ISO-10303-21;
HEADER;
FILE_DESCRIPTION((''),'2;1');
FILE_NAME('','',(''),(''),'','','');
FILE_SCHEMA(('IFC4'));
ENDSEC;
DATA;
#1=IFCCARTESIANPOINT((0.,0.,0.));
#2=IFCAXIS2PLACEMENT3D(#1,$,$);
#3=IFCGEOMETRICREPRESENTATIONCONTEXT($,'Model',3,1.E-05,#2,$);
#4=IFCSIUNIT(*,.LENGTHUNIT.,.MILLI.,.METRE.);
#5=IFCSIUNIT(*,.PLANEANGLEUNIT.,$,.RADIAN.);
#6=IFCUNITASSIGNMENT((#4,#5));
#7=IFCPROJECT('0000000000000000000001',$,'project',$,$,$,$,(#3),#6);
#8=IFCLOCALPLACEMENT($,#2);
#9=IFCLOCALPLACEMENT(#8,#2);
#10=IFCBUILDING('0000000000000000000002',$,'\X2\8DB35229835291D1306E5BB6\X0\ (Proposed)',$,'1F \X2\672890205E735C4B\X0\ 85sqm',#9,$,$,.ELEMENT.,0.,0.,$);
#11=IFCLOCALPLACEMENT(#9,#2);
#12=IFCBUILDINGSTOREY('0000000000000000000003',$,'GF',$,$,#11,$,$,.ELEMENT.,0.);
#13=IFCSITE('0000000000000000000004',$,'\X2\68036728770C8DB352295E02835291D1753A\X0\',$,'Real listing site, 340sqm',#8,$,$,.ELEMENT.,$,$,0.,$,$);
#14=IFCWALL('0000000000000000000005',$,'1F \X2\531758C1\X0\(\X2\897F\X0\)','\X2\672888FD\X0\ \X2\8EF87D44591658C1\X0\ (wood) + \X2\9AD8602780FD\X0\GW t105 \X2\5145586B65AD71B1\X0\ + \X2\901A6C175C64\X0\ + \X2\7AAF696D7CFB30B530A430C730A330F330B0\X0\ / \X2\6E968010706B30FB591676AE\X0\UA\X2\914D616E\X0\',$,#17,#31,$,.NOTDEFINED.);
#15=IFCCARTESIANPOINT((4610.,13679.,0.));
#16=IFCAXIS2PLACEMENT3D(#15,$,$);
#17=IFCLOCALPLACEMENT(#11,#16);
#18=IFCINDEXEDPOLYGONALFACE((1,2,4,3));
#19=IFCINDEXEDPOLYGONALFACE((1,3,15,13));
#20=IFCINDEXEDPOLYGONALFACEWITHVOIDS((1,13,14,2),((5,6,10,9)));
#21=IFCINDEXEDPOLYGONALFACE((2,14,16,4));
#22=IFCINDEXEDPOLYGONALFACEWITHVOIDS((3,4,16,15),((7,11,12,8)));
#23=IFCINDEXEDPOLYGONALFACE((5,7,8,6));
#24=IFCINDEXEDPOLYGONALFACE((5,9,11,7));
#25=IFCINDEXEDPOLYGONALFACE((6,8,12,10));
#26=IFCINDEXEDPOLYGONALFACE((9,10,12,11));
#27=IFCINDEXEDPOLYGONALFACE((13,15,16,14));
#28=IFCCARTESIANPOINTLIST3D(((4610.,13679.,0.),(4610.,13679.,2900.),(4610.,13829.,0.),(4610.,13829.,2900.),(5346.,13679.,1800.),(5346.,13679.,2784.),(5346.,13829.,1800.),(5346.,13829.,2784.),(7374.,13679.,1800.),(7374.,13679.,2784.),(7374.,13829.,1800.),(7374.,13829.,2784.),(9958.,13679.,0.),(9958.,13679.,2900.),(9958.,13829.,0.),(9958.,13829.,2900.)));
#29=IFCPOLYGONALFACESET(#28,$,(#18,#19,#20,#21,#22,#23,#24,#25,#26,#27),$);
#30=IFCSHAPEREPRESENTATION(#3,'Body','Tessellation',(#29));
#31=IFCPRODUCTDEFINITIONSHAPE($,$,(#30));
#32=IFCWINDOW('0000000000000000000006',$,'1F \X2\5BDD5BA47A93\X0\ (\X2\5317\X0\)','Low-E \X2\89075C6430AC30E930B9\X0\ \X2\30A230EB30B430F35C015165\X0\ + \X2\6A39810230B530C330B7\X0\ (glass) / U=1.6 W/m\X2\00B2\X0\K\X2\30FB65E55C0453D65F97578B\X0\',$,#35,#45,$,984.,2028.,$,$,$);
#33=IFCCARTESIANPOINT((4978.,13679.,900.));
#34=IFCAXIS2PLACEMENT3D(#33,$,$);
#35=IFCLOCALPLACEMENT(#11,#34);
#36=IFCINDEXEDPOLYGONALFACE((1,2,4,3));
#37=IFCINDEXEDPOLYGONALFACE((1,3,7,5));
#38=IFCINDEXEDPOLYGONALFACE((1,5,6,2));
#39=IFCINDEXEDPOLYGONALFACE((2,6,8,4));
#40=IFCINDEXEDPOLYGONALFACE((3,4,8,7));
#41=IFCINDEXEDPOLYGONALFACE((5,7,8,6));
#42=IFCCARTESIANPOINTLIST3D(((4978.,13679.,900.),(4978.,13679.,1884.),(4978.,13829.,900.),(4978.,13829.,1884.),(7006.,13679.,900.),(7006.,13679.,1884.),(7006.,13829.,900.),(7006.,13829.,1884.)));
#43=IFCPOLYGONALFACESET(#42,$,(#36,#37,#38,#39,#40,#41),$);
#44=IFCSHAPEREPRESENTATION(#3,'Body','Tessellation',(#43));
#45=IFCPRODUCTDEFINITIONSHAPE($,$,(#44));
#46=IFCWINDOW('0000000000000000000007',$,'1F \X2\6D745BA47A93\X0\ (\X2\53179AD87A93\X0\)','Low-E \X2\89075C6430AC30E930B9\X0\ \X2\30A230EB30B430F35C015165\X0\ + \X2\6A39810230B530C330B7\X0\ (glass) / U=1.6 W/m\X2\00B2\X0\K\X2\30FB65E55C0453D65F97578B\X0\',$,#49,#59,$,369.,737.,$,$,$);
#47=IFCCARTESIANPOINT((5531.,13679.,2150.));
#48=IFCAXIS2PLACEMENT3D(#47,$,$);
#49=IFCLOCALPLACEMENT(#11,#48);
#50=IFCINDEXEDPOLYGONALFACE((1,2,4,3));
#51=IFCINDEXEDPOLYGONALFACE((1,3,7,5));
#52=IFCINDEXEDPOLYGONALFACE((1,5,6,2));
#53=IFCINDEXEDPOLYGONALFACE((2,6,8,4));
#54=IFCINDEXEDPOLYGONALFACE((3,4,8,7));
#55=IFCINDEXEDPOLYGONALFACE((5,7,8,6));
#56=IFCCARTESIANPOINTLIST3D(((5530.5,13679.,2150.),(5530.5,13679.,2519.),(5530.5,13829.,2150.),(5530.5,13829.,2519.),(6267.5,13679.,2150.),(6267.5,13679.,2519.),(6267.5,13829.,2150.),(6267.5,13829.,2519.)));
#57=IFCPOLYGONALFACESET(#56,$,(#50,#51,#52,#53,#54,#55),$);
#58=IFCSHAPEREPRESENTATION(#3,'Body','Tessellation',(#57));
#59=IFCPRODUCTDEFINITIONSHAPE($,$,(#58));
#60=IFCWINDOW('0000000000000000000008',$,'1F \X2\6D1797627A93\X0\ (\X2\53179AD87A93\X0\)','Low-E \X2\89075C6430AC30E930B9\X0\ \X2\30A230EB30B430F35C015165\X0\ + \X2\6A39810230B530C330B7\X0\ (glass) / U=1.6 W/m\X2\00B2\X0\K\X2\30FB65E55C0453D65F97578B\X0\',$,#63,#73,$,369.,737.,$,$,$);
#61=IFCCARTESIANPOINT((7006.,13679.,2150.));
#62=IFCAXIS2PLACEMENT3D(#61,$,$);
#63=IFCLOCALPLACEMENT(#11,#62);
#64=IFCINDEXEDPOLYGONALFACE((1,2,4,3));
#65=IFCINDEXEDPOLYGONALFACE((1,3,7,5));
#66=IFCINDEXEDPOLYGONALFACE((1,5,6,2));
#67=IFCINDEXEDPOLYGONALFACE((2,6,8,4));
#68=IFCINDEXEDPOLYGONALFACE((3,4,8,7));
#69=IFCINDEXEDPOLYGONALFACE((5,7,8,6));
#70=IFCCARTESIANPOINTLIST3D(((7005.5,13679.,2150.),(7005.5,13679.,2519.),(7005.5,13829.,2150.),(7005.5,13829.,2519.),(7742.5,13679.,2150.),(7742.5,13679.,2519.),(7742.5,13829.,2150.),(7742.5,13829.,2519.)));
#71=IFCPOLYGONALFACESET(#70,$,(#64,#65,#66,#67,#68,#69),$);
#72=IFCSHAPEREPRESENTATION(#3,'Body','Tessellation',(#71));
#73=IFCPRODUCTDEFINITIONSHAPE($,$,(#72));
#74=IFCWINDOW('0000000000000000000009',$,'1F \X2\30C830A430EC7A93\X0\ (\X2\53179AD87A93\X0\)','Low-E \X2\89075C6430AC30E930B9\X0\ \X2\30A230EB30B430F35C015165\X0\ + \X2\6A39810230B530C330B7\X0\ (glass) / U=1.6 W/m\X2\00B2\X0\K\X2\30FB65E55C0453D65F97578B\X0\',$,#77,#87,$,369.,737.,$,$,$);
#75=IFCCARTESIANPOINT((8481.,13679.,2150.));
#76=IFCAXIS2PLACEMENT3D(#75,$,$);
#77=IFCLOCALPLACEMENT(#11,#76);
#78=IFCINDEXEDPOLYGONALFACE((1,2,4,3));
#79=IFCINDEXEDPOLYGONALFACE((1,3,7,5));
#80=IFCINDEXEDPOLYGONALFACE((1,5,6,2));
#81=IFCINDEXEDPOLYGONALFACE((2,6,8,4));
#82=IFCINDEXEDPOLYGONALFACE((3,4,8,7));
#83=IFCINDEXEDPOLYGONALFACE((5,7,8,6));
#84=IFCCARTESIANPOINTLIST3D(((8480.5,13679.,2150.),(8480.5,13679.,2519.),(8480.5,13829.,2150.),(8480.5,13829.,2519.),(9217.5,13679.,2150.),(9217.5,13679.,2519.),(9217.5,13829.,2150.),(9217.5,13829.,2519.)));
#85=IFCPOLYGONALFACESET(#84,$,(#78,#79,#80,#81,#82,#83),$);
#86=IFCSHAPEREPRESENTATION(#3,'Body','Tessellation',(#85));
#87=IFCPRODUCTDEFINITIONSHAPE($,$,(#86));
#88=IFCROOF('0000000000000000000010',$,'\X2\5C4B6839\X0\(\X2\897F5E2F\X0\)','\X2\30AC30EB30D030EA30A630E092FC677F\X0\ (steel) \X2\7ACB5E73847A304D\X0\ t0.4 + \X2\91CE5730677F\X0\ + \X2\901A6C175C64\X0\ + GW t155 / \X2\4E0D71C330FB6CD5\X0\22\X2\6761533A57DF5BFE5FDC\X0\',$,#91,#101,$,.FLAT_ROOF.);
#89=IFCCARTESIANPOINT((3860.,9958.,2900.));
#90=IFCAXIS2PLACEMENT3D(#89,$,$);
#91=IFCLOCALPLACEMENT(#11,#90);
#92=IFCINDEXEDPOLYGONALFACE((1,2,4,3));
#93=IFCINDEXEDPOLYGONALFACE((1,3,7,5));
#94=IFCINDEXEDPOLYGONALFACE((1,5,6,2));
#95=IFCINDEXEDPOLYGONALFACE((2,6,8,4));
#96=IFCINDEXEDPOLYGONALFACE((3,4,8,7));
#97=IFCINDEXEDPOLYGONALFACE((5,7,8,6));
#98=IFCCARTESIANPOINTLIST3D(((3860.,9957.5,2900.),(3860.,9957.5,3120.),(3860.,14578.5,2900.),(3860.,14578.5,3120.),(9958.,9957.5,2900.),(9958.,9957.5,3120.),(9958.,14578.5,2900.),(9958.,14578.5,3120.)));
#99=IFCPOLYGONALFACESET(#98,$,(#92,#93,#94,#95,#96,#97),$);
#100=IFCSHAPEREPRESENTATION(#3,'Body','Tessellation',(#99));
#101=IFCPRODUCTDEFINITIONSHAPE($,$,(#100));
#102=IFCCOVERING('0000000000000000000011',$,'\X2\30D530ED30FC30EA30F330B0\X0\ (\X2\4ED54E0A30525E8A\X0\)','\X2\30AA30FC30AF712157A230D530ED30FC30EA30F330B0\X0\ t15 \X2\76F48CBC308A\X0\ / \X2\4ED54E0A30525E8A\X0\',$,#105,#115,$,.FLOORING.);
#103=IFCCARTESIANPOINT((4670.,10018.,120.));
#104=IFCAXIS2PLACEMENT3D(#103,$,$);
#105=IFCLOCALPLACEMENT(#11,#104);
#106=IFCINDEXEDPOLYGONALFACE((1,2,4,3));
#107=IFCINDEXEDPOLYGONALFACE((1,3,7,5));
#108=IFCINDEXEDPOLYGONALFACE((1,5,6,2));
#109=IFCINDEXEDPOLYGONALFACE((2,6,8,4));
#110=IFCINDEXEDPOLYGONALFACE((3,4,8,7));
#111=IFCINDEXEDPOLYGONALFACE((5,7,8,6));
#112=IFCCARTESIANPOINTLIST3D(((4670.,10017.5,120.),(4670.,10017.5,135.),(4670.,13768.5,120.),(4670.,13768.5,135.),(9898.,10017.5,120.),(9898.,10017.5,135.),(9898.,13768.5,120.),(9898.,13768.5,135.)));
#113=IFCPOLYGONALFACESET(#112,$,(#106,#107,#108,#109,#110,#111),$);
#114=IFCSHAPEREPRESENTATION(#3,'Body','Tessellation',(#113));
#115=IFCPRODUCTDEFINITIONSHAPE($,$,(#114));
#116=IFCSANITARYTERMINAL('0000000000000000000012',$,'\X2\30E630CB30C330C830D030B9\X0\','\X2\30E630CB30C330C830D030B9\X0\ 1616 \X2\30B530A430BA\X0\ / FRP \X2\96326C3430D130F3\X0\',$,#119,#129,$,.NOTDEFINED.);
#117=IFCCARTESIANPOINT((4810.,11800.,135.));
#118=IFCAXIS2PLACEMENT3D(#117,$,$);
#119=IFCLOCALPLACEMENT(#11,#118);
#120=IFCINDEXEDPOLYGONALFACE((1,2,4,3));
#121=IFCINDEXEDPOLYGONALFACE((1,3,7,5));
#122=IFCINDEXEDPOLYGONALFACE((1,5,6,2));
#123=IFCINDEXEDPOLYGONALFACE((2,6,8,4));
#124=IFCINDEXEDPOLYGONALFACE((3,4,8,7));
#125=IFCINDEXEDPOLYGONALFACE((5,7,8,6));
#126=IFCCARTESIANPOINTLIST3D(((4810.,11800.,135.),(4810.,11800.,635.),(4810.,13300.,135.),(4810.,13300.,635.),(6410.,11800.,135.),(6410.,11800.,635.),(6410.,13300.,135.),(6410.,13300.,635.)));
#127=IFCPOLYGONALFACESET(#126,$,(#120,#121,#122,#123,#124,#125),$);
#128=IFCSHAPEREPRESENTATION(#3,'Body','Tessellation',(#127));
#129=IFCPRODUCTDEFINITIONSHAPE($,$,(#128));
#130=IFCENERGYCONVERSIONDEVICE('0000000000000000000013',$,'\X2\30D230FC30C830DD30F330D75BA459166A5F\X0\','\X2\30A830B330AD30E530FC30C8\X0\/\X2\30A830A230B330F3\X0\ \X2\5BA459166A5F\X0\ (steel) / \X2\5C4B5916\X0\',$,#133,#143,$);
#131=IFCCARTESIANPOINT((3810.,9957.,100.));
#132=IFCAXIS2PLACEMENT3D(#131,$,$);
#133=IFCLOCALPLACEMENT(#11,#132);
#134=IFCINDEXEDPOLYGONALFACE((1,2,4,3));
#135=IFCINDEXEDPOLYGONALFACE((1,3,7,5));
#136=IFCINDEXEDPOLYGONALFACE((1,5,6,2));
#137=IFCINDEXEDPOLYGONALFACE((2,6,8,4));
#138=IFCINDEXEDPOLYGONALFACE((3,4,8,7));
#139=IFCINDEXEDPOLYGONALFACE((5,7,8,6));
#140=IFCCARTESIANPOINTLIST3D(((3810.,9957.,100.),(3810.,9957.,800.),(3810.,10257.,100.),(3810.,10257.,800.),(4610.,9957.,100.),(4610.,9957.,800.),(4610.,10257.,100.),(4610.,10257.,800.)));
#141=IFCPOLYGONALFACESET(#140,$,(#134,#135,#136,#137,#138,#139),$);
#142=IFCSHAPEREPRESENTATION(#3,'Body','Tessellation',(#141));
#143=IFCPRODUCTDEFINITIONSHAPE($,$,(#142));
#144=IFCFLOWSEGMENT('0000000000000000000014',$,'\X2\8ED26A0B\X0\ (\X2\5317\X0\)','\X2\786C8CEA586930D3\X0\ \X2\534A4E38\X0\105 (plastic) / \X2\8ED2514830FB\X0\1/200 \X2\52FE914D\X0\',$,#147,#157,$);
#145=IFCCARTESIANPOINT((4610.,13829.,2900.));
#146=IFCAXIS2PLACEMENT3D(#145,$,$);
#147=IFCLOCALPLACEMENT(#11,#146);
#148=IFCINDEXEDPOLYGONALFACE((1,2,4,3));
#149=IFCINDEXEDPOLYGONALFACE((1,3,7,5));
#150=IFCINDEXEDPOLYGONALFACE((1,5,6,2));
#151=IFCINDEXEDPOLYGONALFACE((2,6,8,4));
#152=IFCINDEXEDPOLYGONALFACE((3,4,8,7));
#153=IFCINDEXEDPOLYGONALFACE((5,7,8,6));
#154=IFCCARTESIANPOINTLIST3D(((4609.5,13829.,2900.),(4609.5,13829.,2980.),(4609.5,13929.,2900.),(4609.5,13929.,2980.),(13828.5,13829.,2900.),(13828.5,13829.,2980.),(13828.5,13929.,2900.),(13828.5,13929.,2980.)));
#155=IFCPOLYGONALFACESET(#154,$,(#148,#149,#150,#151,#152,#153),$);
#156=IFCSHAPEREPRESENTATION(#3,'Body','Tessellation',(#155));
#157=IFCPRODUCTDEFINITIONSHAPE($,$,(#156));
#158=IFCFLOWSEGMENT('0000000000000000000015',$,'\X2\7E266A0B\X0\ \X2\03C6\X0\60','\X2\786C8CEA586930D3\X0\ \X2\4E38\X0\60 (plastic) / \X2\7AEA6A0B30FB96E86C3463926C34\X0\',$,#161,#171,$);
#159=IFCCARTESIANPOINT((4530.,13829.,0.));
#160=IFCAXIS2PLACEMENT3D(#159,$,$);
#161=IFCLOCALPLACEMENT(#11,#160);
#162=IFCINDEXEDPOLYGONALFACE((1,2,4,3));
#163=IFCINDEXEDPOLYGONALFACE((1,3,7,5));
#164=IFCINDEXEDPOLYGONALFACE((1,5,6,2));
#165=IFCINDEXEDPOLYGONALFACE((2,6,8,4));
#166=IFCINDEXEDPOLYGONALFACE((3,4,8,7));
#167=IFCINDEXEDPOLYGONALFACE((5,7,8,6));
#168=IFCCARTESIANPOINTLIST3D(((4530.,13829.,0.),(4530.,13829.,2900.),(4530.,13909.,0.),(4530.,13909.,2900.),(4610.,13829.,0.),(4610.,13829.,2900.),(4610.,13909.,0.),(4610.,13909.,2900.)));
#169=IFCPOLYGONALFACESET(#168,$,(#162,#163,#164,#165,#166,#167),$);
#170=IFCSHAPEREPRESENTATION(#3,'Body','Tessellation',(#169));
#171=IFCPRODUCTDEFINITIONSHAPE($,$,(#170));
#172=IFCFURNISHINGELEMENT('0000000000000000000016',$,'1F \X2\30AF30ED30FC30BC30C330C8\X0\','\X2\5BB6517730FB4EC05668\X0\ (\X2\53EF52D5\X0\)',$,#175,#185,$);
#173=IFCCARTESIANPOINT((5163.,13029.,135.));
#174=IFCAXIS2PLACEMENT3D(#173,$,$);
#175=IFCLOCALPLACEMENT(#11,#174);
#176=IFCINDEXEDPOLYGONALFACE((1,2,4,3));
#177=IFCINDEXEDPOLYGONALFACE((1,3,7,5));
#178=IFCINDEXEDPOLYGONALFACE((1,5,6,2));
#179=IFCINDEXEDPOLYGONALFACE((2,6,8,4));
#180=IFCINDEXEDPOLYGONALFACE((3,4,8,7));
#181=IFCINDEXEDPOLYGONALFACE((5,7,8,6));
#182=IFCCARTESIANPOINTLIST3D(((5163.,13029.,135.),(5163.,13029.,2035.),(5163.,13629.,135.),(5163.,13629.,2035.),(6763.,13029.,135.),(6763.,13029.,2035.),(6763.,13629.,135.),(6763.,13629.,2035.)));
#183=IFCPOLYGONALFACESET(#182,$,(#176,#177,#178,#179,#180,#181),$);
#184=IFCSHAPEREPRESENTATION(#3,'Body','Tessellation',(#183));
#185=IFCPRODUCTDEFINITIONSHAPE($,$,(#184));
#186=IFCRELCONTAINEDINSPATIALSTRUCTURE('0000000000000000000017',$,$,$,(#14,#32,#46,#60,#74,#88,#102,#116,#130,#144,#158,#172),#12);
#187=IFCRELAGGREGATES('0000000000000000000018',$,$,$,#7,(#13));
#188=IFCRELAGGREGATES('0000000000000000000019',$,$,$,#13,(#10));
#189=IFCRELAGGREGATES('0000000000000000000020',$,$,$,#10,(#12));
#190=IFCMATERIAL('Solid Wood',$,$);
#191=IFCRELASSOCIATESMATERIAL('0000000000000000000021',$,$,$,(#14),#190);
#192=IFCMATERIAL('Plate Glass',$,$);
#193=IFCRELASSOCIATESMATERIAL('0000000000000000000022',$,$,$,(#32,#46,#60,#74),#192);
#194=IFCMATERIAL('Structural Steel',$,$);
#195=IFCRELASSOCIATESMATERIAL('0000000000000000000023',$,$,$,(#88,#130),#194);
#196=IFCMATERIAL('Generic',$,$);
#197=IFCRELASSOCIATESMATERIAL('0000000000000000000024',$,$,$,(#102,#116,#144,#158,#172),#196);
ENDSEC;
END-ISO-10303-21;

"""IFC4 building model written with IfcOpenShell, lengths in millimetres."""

from ifc_helpers import new_model, si_unit, frame, frame_2d, origin, place, context, project, spatial, rectangle, extrude, material, element, fill, save


model = new_model("IFC4")

# Units and contexts
model_context = context("Model", 3, precision=1e-05, world=origin())
ifc_project = project(units=[si_unit("LENGTHUNIT", "METRE", prefix="MILLI"), si_unit("PLANEANGLEUNIT", "RADIAN")], contexts=[model_context])

# Site, building, storey
site_placement = place(None, origin())
site = spatial("IfcSite", under=ifc_project, at=site_placement, Name="栃木県足利市荒金町", ObjectType="Real listing site, 340sqm", CompositionType="ELEMENT", RefElevation=0.0)
building_placement = place(site_placement, origin())
building = spatial("IfcBuilding", under=site, at=building_placement, Name="足利荒金の家 (Proposed)", ObjectType="1F 木造平屋 85sqm", CompositionType="ELEMENT", ElevationOfRefHeight=0.0, ElevationOfTerrain=0.0)
storey_placement = place(building_placement, origin())
storey = spatial("IfcBuildingStorey", under=building, at=storey_placement, Name="GF", CompositionType="ELEMENT", Elevation=0.0)

# Shared definitions
ifc_material_1 = material(Name="Solid Wood")

# Wall, openings, windows
wall_1_placement = place(storey_placement, frame((4610.0, 13679.0, 0.0)))
wall_1 = element("IfcWall", 1, at=wall_1_placement, inside=storey, material=ifc_material_1, Name="1F 北壁(西)", Description="木製 軸組外壁 (wood) + 高性能GW t105 充填断熱 + 通気層 + 窯業系サイディング / 準耐火・外皮UA配慮", PredefinedType="NOTDEFINED", context=model_context, shape_type="SweptSolid", body=[
    extrude(rectangle(XDim=5348.0, YDim=150.0, at=frame_2d((2674.0, 75.0))), frame((4610.0, 13679.0, 0.0)), (0.0, 0.0, 1.0), 2900.0),
])
opening_1_placement = place(storey_placement, frame((4978.0, 13679.0, 900.0)))
opening_1 = element("IfcOpeningElement", 2, at=opening_1_placement, cuts=wall_1, PredefinedType="NOTDEFINED", context=model_context, shape_type="SweptSolid", body=[
    extrude(rectangle(XDim=2028.0, YDim=150.0, at=frame_2d((1014.0, 75.0))), frame((4978.0, 13679.0, 900.0)), (0.0, 0.0, 1.0), 984.0),
])
opening_2_placement = place(storey_placement, frame((5531.0, 13679.0, 2150.0)))
opening_2 = element("IfcOpeningElement", 3, at=opening_2_placement, cuts=wall_1, PredefinedType="NOTDEFINED", context=model_context, shape_type="SweptSolid", body=[
    extrude(rectangle(XDim=737.0, YDim=150.0, at=frame_2d((368.0, 75.0))), frame((5531.0, 13679.0, 2150.0)), (0.0, 0.0, 1.0), 369.0),
])
opening_3_placement = place(storey_placement, frame((7006.0, 13679.0, 2150.0)))
opening_3 = element("IfcOpeningElement", 4, at=opening_3_placement, cuts=wall_1, PredefinedType="NOTDEFINED", context=model_context, shape_type="SweptSolid", body=[
    extrude(rectangle(XDim=737.0, YDim=150.0, at=frame_2d((368.0, 75.0))), frame((7006.0, 13679.0, 2150.0)), (0.0, 0.0, 1.0), 369.0),
])
opening_4_placement = place(storey_placement, frame((8481.0, 13679.0, 2150.0)))
opening_4 = element("IfcOpeningElement", 5, at=opening_4_placement, cuts=wall_1, PredefinedType="NOTDEFINED", context=model_context, shape_type="SweptSolid", body=[
    extrude(rectangle(XDim=737.0, YDim=150.0, at=frame_2d((368.0, 75.0))), frame((8481.0, 13679.0, 2150.0)), (0.0, 0.0, 1.0), 369.0),
])
ifc_material_2 = material(Name="Plate Glass")
window_1_placement = place(storey_placement, frame((4978.0, 13679.0, 900.0)))
window_1 = element("IfcWindow", 6, at=window_1_placement, inside=storey, material=ifc_material_2, Name="1F 寝室窓 (北)", Description="Low-E 複層ガラス アルゴン封入 + 樹脂サッシ (glass) / U=1.6 W/m²K・日射取得型", OverallHeight=984.0, OverallWidth=2028.0, context=model_context, shape_type="SweptSolid", body=[
    extrude(rectangle(XDim=2028.0, YDim=150.0, at=frame_2d((1014.0, 75.0))), frame((4978.0, 13679.0, 900.0)), (0.0, 0.0, 1.0), 984.0),
])
fill(opening_1, window_1)
window_2_placement = place(storey_placement, frame((5531.0, 13679.0, 2150.0)))
window_2 = element("IfcWindow", 7, at=window_2_placement, inside=storey, material=ifc_material_2, Name="1F 浴室窓 (北高窓)", Description="Low-E 複層ガラス アルゴン封入 + 樹脂サッシ (glass) / U=1.6 W/m²K・日射取得型", OverallHeight=369.0, OverallWidth=737.0, context=model_context, shape_type="SweptSolid", body=[
    extrude(rectangle(XDim=737.0, YDim=150.0, at=frame_2d((368.0, 75.0))), frame((5531.0, 13679.0, 2150.0)), (0.0, 0.0, 1.0), 369.0),
])
fill(opening_2, window_2)
window_3_placement = place(storey_placement, frame((7006.0, 13679.0, 2150.0)))
window_3 = element("IfcWindow", 8, at=window_3_placement, inside=storey, material=ifc_material_2, Name="1F 洗面窓 (北高窓)", Description="Low-E 複層ガラス アルゴン封入 + 樹脂サッシ (glass) / U=1.6 W/m²K・日射取得型", OverallHeight=369.0, OverallWidth=737.0, context=model_context, shape_type="SweptSolid", body=[
    extrude(rectangle(XDim=737.0, YDim=150.0, at=frame_2d((368.0, 75.0))), frame((7006.0, 13679.0, 2150.0)), (0.0, 0.0, 1.0), 369.0),
])
fill(opening_3, window_3)
window_4_placement = place(storey_placement, frame((8481.0, 13679.0, 2150.0)))
window_4 = element("IfcWindow", 9, at=window_4_placement, inside=storey, material=ifc_material_2, Name="1F トイレ窓 (北高窓)", Description="Low-E 複層ガラス アルゴン封入 + 樹脂サッシ (glass) / U=1.6 W/m²K・日射取得型", OverallHeight=369.0, OverallWidth=737.0, context=model_context, shape_type="SweptSolid", body=[
    extrude(rectangle(XDim=737.0, YDim=150.0, at=frame_2d((368.0, 75.0))), frame((8481.0, 13679.0, 2150.0)), (0.0, 0.0, 1.0), 369.0),
])
fill(opening_4, window_4)

# Roof
ifc_material_3 = material(Name="Structural Steel")
roof_placement = place(storey_placement, frame((3860.0, 9958.0, 2900.0)))
element("IfcRoof", 10, at=roof_placement, inside=storey, material=ifc_material_3, Name="屋根(西帯)", Description="ガルバリウム鋼板 (steel) 立平葺き t0.4 + 野地板 + 通気層 + GW t155 / 不燃・法22条区域対応", PredefinedType="FLAT_ROOF", context=model_context, shape_type="SweptSolid", body=[
    extrude(rectangle(XDim=6098.0, YDim=4621.0, at=frame_2d((3049.0, 2310.0))), frame((3860.0, 9958.0, 2900.0)), (0.0, 0.0, 1.0), 220.0),
])

# Covering
ifc_material_4 = material(Name="Generic")
covering_placement = place(storey_placement, frame((4670.0, 10018.0, 120.0)))
element("IfcCovering", 11, at=covering_placement, inside=storey, material=ifc_material_4, Name="フローリング (仕上げ床)", Description="オーク無垢フローリング t15 直貼り / 仕上げ床", PredefinedType="FLOORING", context=model_context, shape_type="SweptSolid", body=[
    extrude(rectangle(XDim=5228.0, YDim=3751.0, at=frame_2d((2614.0, 1875.0))), frame((4670.0, 10018.0, 120.0)), (0.0, 0.0, 1.0), 15.0),
])

# Sanitary terminal
sanitary_terminal_placement = place(storey_placement, frame((4810.0, 11800.0, 135.0)))
element("IfcSanitaryTerminal", 12, at=sanitary_terminal_placement, inside=storey, material=ifc_material_4, Name="ユニットバス", Description="ユニットバス 1616 サイズ / FRP 防水パン", PredefinedType="NOTDEFINED", context=model_context, shape_type="SweptSolid", body=[
    extrude(rectangle(XDim=1600.0, YDim=1500.0, at=frame_2d((800.0, 750.0))), frame((4810.0, 11800.0, 135.0)), (0.0, 0.0, 1.0), 500.0),
])

# Energy conversion device
energy_conversion_device_placement = place(storey_placement, frame((3810.0, 9957.0, 100.0)))
element("IfcEnergyConversionDevice", 13, at=energy_conversion_device_placement, inside=storey, material=ifc_material_3, Name="ヒートポンプ室外機", Description="エコキュート/エアコン 室外機 (steel) / 屋外", context=model_context, shape_type="SweptSolid", body=[
    extrude(rectangle(XDim=800.0, YDim=300.0, at=frame_2d((400.0, 150.0))), frame((3810.0, 9957.0, 100.0)), (0.0, 0.0, 1.0), 700.0),
])

# Flow segments
flow_segment_1_placement = place(storey_placement, frame((4610.0, 13829.0, 2900.0)))
element("IfcFlowSegment", 14, at=flow_segment_1_placement, inside=storey, material=ifc_material_4, Name="軒樋 (北)", Description="硬質塩ビ 半丸105 (plastic) / 軒先・1/200 勾配", context=model_context, shape_type="SweptSolid", body=[
    extrude(rectangle(XDim=9219.0, YDim=100.0, at=frame_2d((4609.0, 50.0))), frame((4610.0, 13829.0, 2900.0)), (0.0, 0.0, 1.0), 80.0),
])
flow_segment_2_placement = place(storey_placement, frame((4530.0, 13829.0, 0.0)))
element("IfcFlowSegment", 15, at=flow_segment_2_placement, inside=storey, material=ifc_material_4, Name="縦樋 φ60", Description="硬質塩ビ 丸60 (plastic) / 竪樋・雨水排水", context=model_context, shape_type="SweptSolid", body=[
    extrude(rectangle(XDim=80.0, YDim=80.0, at=frame_2d((40.0, 40.0))), frame((4530.0, 13829.0, 0.0)), (0.0, 0.0, 1.0), 2900.0),
])

# Furnishing element
furnishing_1_placement = place(storey_placement, frame((5163.0, 13029.0, 135.0)))
element("IfcFurnishingElement", 16, at=furnishing_1_placement, inside=storey, material=ifc_material_4, Name="1F クローゼット", Description="家具・什器 (可動)", context=model_context, shape_type="SweptSolid", body=[
    extrude(rectangle(XDim=1600.0, YDim=600.0, at=frame_2d((800.0, 300.0))), frame((5163.0, 13029.0, 135.0)), (0.0, 0.0, 1.0), 1900.0),
])

save(model, "model.ifc")
